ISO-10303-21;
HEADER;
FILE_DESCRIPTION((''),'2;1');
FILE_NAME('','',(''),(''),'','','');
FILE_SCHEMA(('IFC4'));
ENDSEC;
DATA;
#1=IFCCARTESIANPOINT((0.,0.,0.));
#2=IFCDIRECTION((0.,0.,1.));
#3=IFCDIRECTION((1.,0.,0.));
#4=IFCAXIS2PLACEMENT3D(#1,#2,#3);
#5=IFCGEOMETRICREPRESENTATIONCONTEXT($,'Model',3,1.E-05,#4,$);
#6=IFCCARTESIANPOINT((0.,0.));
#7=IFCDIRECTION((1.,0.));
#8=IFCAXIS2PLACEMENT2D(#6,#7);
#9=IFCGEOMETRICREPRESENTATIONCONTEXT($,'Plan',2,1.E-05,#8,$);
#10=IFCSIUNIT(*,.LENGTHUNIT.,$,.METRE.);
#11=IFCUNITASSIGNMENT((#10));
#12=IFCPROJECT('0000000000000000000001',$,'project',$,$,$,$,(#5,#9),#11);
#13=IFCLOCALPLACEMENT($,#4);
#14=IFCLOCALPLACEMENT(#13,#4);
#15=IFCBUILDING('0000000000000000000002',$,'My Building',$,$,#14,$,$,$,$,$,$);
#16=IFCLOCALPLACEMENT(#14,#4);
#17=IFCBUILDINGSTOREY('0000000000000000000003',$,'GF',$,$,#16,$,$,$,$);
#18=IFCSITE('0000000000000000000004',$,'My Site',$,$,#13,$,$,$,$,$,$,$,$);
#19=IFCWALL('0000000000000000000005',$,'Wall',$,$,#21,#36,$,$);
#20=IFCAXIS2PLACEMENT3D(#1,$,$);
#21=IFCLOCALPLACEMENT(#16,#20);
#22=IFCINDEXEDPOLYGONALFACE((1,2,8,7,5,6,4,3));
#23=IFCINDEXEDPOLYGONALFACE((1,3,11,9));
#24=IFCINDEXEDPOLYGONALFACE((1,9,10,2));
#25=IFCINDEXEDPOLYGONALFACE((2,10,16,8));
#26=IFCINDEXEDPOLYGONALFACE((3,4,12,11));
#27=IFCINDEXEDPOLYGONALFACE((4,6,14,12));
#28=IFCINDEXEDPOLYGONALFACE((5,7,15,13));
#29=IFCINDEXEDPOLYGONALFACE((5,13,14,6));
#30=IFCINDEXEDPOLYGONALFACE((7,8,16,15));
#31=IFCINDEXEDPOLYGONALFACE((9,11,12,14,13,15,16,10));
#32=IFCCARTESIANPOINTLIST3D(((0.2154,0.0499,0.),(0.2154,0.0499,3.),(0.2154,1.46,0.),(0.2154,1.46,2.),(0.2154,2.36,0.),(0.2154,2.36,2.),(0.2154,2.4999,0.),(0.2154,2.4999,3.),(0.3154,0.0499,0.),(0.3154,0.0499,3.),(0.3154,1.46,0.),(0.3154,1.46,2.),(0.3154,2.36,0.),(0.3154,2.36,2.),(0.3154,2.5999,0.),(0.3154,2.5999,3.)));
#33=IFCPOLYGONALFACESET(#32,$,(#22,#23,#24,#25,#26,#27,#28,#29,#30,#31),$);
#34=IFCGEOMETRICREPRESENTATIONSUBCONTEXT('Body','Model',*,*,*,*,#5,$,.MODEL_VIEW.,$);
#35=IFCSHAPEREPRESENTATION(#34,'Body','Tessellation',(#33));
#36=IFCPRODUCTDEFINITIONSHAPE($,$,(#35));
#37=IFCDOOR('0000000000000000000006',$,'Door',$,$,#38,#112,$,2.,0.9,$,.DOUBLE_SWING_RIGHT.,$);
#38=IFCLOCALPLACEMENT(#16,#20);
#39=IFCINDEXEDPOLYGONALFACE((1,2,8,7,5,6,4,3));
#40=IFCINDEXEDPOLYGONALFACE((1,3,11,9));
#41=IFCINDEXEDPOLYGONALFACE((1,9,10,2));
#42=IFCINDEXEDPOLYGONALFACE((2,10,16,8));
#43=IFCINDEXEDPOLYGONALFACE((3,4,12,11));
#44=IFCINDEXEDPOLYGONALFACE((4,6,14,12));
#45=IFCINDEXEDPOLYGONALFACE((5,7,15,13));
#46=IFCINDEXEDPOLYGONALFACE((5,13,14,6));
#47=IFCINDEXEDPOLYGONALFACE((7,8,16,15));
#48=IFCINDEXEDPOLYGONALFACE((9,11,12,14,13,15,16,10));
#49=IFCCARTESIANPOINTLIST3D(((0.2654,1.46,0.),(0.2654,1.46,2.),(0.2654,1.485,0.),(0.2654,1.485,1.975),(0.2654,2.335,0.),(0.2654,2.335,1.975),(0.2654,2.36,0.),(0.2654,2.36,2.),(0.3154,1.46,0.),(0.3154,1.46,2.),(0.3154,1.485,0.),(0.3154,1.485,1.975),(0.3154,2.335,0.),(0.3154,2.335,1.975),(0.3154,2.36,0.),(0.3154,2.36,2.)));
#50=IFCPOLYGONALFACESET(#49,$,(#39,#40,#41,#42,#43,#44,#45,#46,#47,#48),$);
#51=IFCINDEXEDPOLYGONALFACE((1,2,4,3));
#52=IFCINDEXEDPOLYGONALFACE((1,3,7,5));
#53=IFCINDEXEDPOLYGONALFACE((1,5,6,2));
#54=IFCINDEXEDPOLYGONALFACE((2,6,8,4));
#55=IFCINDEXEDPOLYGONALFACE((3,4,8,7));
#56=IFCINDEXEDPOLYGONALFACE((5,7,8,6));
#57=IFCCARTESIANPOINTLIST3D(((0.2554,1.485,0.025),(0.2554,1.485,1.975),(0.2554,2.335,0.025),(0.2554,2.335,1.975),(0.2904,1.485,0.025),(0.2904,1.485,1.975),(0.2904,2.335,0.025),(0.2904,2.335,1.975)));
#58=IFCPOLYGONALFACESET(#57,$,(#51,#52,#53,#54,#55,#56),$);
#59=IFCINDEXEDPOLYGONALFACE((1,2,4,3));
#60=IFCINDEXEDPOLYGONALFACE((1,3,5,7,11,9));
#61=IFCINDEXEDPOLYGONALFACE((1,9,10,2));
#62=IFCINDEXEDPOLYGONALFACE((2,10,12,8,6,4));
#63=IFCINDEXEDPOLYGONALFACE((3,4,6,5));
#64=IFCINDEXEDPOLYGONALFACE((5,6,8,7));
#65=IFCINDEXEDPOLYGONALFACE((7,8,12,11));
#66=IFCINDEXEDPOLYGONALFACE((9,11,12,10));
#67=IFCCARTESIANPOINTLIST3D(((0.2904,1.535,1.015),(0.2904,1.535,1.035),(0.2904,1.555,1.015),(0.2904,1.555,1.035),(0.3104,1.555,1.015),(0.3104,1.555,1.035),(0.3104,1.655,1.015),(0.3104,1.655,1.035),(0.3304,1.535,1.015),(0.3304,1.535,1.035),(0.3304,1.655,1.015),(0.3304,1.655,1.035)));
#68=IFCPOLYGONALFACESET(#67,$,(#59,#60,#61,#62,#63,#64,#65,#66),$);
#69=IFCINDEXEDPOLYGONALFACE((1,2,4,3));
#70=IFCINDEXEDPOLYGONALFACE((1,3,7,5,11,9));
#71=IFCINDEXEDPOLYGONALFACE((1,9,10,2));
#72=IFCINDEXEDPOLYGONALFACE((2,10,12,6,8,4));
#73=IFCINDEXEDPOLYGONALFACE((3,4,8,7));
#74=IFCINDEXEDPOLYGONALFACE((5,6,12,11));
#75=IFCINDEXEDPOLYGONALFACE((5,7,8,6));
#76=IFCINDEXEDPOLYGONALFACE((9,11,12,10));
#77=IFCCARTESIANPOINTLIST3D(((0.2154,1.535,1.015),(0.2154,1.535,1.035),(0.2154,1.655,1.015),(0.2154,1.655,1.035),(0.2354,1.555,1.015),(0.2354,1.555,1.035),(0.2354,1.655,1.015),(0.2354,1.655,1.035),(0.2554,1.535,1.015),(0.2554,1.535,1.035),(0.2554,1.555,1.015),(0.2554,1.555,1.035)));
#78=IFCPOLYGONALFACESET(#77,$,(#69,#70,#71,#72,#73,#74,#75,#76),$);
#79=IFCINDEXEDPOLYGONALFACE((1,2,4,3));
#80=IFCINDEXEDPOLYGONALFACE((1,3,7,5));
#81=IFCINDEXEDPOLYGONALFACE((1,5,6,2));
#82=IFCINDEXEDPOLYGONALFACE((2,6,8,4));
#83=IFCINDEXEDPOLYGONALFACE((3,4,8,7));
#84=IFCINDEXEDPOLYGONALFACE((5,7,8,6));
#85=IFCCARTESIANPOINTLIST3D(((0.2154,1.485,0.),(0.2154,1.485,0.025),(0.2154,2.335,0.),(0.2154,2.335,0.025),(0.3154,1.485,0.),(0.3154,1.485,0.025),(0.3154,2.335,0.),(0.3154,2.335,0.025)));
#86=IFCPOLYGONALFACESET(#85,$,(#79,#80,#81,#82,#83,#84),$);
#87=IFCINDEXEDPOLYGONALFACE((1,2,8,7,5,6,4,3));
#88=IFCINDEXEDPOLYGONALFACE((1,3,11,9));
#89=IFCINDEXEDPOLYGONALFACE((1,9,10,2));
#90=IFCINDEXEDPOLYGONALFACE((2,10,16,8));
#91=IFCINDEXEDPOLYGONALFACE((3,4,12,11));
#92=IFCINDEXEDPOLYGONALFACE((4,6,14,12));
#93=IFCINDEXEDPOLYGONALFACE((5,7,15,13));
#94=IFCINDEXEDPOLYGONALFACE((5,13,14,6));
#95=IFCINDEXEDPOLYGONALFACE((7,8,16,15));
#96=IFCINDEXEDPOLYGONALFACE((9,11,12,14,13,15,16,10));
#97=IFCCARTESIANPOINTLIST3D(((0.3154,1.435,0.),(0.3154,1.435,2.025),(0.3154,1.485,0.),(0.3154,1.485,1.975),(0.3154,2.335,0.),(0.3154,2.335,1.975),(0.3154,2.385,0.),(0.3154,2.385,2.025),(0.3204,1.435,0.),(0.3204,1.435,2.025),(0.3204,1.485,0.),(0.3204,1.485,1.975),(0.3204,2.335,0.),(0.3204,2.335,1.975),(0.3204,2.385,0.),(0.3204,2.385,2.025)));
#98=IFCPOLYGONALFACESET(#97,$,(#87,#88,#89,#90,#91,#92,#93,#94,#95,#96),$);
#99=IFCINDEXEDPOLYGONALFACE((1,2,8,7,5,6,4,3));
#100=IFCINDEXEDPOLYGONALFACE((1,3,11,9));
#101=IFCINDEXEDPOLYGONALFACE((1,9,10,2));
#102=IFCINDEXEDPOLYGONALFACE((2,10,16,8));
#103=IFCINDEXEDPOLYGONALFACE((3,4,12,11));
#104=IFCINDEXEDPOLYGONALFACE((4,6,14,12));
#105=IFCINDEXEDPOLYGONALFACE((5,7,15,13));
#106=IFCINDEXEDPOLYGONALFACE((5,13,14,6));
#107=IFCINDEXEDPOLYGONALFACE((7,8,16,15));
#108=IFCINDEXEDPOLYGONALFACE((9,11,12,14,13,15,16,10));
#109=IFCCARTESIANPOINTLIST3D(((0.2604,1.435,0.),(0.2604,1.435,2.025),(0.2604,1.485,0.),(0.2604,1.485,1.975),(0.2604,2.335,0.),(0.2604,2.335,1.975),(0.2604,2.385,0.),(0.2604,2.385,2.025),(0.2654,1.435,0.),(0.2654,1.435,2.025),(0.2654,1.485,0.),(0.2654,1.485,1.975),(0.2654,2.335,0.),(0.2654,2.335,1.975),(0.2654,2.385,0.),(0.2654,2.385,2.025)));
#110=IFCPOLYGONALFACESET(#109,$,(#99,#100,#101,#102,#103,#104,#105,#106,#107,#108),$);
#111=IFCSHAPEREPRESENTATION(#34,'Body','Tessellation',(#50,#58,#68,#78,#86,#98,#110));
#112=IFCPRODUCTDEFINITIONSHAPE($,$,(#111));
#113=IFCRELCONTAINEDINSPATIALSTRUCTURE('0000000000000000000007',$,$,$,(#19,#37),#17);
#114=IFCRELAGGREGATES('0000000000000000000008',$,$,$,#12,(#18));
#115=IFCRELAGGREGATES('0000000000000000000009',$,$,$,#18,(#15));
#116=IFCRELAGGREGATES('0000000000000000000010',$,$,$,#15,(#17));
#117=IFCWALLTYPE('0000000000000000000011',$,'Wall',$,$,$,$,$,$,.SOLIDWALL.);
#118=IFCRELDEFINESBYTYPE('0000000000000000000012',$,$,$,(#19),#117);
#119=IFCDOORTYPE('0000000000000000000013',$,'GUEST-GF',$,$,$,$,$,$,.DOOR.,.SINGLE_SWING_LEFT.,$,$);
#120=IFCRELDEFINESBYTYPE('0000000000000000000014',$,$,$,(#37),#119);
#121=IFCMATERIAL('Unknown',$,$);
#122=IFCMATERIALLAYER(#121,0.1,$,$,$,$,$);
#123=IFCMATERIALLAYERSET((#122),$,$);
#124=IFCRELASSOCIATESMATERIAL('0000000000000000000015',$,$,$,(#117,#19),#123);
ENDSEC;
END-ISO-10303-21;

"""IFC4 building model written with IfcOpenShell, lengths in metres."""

from ifc_helpers import new_model, entity, si_unit, frame, origin_with_axes, origin_2d_with_axis, place, context, subcontext, project, spatial, line, indexed_curve, outline, extrude, shape, source, transform, mapped, material, layer, layer_set, layer_usage, type_object, type_shapes, element, fill, save


model = new_model("IFC4")

# Units and contexts
model_context = context("Model", 3, precision=1e-05, world=origin_with_axes())
plan_context = context("Plan", 2, precision=1e-05, world=origin_2d_with_axis())
body_context_1 = subcontext(model_context, "Body", "Model", "MODEL_VIEW")
body_context_2 = subcontext(plan_context, "Body", "Plan", "PLAN_VIEW")
ifc_project = project(units=[si_unit("LENGTHUNIT", "METRE")], contexts=[model_context, plan_context])

# Site, building, storey
site_placement = place(None, origin_with_axes())
site = spatial("IfcSite", under=ifc_project, at=site_placement, Name="My Site")
building_placement = place(site_placement, origin_with_axes())
building = spatial("IfcBuilding", under=site, at=building_placement, Name="My Building")
storey_placement = place(building_placement, origin_with_axes())
storey = spatial("IfcBuildingStorey", under=building, at=storey_placement, Name="GF")

# Shared definitions
ifc_material = material(Name="Unknown")

# Shared definitions
ifc_layer_1 = layer(ifc_material, 0.1)
ifc_layer_set_1 = layer_set([ifc_layer_1])
wall_type = type_object("IfcWallType", Name="Wall", PredefinedType="SOLIDWALL", material=ifc_layer_set_1)

# Wall, opening, door
ifc_layer_usage_1 = layer_usage(ifc_layer_set_1, "AXIS2", "POSITIVE", 0.0)
wall_1_placement = place(storey_placement, frame((0.3154, 0.0499, 0.0), z_axis=(0.0, 0.0, 1.0), x_axis=(0.0, 1.0, 0.0)))
wall_1 = element("IfcWall", 1, at=wall_1_placement, inside=storey, type_object=wall_type, material=ifc_layer_usage_1, Name="Wall", context=body_context_1, shape_type="SweptSolid", body=[
    extrude(outline(indexed_curve([(0.0, 0.0), (0.0, 0.1), (2.45, 0.1), (2.55, 0.0)], segments=[line(1, 2, 3, 4, 1)])), origin_with_axes(), (0.0, 0.0, 1.0), 3.0),
])
shared_shape_1 = source(origin_with_axes(), body_context_1, "Body", "SweptSolid", [
    extrude(outline(indexed_curve([(0.0, 0.0), (0.9, 0.0), (0.9, 2.0), (0.0, 2.0)], segments=[line(1, 2, 3, 4, 1)])), frame((0.0, -0.6, 0.0), z_axis=(0.0, -1.0, 0.0), x_axis=(1.0, 0.0, 0.0)), (0.0, 0.0, -1.0), 1.2),
])
opening_1_placement = place(wall_1_placement, frame((1.4101, 0.0, 0.0), z_axis=(0.0, 0.0, 1.0), x_axis=(1.0, 0.0, 0.0)))
opening_1 = element("IfcOpeningElement", 2, at=opening_1_placement, cuts=wall_1, PredefinedType="OPENING", context=body_context_1, shape_type="MappedRepresentation", body=[
    mapped(shared_shape_1, transform((0.0, 0.0, 0.0), x_axis=(1.0, 0.0, 0.0), y_axis=(0.0, 1.0, 0.0), z_axis=(0.0, 0.0, 1.0), scale=1.0)),
])
door_type_1 = type_object("IfcDoorType", Name="GUEST-GF", OperationType="SINGLE_SWING_LEFT", PredefinedType="DOOR")
shared_shape_2 = source(origin_with_axes(), body_context_1, "Body", "SweptSolid", [
    extrude(outline(indexed_curve([(0.0, 0.0), (0.0, 2.0), (0.9, 2.0), (0.9, 0.0), (0.875, 0.0), (0.875, 1.975), (0.025, 1.975), (0.025, 0.0)], segments=[line(1, 2, 3, 4, 5, 6, 7, 8, 1)])), frame((0.0, 0.0, 0.0), z_axis=(0.0, -1.0, 0.0), x_axis=(1.0, 0.0, 0.0)), (0.0, 0.0, -1.0), 0.05),
    extrude(outline(indexed_curve([(0.0, 0.0), (0.85, 0.0), (0.85, 0.035), (0.0, 0.035)], segments=[line(1, 2, 3, 4, 1)])), frame((0.025, 0.025, 0.025), z_axis=(0.0, 0.0, 1.0), x_axis=(1.0, 0.0, 0.0)), (0.0, 0.0, 1.0), 1.95),
    extrude(outline(indexed_curve([(0.0, 0.0), (0.0, -0.04), (0.12, -0.04), (0.12, -0.02), (0.02, -0.02), (0.02, 0.0)], segments=[line(1, 2, 3, 4, 5, 6, 1)])), frame((0.075, 0.025, 1.015), z_axis=(0.0, 0.0, 1.0), x_axis=(1.0, 0.0, 0.0)), (0.0, 0.0, 1.0), 0.02),
    extrude(outline(indexed_curve([(0.0, 0.0), (0.0, 0.04), (0.12, 0.04), (0.12, 0.02), (0.02, 0.02), (0.02, 0.0)], segments=[line(1, 2, 3, 4, 5, 6, 1)])), frame((0.075, 0.06, 1.015), z_axis=(0.0, 0.0, 1.0), x_axis=(1.0, 0.0, 0.0)), (0.0, 0.0, 1.0), 0.02),
    extrude(outline(indexed_curve([(0.0, 0.0), (0.85, 0.0), (0.85, 0.1), (0.0, 0.1)], segments=[line(1, 2, 3, 4, 1)])), frame((0.025, 0.0, 0.0), z_axis=(0.0, 0.0, 1.0), x_axis=(1.0, 0.0, 0.0)), (0.0, 0.0, 1.0), 0.025),
    extrude(outline(indexed_curve([(0.0, 0.0), (0.0, 2.025), (0.95, 2.025), (0.95, 0.0), (0.9, 0.0), (0.9, 1.975), (0.05, 1.975), (0.05, 0.0)], segments=[line(1, 2, 3, 4, 5, 6, 7, 8, 1)])), frame((-0.025, -0.005, 0.0), z_axis=(0.0, -1.0, 0.0), x_axis=(1.0, 0.0, 0.0)), (0.0, 0.0, -1.0), 0.005),
    extrude(outline(indexed_curve([(0.0, 0.0), (0.0, 2.025), (0.95, 2.025), (0.95, 0.0), (0.9, 0.0), (0.9, 1.975), (0.05, 1.975), (0.05, 0.0)], segments=[line(1, 2, 3, 4, 5, 6, 7, 8, 1)])), frame((-0.025, 0.05, 0.0), z_axis=(0.0, -1.0, 0.0), x_axis=(1.0, 0.0, 0.0)), (0.0, 0.0, -1.0), 0.005),
])
shared_shape_3 = source(origin_with_axes(), body_context_2, "Body", "Curve2D", [
    entity("IfcIndexedPolyCurve", entity("IfcCartesianPointList2D", [[0.0, 0.0], [0.025, 0.0], [0.025, 0.05], [0.0, 0.05]]), [entity("IfcLineIndex", [1, 2, 3, 4, 1])]),
    entity("IfcIndexedPolyCurve", entity("IfcCartesianPointList2D", [[0.9, 0.0], [0.875, 0.0], [0.875, 0.05], [0.9, 0.05]]), [entity("IfcLineIndex", [1, 2, 3, 4, 1])]),
    entity("IfcIndexedPolyCurve", entity("IfcCartesianPointList2D", [[0.875, 0.05], [0.875, -0.8], [0.84, -0.8]])),
    entity("IfcTrimmedCurve", entity("IfcEllipse", entity("IfcAxis2Placement2D", entity("IfcCartesianPoint", [0.84, 0.05]), entity("IfcDirection", [1.0, 0.0])), 0.815, 0.85), [entity("IfcCartesianPoint", [0.84, 0.9])], [entity("IfcCartesianPoint", [0.84, -0.8])], True, "CARTESIAN"),
    entity("IfcIndexedPolyCurve", entity("IfcCartesianPointList2D", [[0.875, 0.05], [0.84, 0.05], [0.84, 0.9], [0.875, 0.9]]), [entity("IfcLineIndex", [1, 2, 3, 4, 1])]),
])
type_shapes(door_type_1, [shared_shape_2, shared_shape_3])
door_1_placement = place(opening_1_placement, frame((0.0, 0.0, 0.0), z_axis=(0.0, 0.0, 1.0), x_axis=(1.0, 0.0, 0.0)))
door_1 = element("IfcDoor", 3, at=door_1_placement, inside=storey, type_object=door_type_1, Name="Door", OperationType="DOUBLE_SWING_RIGHT", OverallHeight=2.0, OverallWidth=0.9, shapes=[
    shape(body_context_1, "Body", "MappedRepresentation", [mapped(shared_shape_2, transform((0.0, 0.0, 0.0), x_axis=(1.0, 0.0, 0.0), y_axis=(0.0, 1.0, 0.0), z_axis=(0.0, 0.0, 1.0), scale=1.0))]),
    shape(body_context_2, "Body", "MappedRepresentation", [mapped(shared_shape_3, transform((0.0, 0.0, 0.0), x_axis=(1.0, 0.0, 0.0), y_axis=(0.0, 1.0, 0.0), z_axis=(0.0, 0.0, 1.0), scale=1.0))]),
])
fill(opening_1, door_1)

save(model, "model.ifc")
